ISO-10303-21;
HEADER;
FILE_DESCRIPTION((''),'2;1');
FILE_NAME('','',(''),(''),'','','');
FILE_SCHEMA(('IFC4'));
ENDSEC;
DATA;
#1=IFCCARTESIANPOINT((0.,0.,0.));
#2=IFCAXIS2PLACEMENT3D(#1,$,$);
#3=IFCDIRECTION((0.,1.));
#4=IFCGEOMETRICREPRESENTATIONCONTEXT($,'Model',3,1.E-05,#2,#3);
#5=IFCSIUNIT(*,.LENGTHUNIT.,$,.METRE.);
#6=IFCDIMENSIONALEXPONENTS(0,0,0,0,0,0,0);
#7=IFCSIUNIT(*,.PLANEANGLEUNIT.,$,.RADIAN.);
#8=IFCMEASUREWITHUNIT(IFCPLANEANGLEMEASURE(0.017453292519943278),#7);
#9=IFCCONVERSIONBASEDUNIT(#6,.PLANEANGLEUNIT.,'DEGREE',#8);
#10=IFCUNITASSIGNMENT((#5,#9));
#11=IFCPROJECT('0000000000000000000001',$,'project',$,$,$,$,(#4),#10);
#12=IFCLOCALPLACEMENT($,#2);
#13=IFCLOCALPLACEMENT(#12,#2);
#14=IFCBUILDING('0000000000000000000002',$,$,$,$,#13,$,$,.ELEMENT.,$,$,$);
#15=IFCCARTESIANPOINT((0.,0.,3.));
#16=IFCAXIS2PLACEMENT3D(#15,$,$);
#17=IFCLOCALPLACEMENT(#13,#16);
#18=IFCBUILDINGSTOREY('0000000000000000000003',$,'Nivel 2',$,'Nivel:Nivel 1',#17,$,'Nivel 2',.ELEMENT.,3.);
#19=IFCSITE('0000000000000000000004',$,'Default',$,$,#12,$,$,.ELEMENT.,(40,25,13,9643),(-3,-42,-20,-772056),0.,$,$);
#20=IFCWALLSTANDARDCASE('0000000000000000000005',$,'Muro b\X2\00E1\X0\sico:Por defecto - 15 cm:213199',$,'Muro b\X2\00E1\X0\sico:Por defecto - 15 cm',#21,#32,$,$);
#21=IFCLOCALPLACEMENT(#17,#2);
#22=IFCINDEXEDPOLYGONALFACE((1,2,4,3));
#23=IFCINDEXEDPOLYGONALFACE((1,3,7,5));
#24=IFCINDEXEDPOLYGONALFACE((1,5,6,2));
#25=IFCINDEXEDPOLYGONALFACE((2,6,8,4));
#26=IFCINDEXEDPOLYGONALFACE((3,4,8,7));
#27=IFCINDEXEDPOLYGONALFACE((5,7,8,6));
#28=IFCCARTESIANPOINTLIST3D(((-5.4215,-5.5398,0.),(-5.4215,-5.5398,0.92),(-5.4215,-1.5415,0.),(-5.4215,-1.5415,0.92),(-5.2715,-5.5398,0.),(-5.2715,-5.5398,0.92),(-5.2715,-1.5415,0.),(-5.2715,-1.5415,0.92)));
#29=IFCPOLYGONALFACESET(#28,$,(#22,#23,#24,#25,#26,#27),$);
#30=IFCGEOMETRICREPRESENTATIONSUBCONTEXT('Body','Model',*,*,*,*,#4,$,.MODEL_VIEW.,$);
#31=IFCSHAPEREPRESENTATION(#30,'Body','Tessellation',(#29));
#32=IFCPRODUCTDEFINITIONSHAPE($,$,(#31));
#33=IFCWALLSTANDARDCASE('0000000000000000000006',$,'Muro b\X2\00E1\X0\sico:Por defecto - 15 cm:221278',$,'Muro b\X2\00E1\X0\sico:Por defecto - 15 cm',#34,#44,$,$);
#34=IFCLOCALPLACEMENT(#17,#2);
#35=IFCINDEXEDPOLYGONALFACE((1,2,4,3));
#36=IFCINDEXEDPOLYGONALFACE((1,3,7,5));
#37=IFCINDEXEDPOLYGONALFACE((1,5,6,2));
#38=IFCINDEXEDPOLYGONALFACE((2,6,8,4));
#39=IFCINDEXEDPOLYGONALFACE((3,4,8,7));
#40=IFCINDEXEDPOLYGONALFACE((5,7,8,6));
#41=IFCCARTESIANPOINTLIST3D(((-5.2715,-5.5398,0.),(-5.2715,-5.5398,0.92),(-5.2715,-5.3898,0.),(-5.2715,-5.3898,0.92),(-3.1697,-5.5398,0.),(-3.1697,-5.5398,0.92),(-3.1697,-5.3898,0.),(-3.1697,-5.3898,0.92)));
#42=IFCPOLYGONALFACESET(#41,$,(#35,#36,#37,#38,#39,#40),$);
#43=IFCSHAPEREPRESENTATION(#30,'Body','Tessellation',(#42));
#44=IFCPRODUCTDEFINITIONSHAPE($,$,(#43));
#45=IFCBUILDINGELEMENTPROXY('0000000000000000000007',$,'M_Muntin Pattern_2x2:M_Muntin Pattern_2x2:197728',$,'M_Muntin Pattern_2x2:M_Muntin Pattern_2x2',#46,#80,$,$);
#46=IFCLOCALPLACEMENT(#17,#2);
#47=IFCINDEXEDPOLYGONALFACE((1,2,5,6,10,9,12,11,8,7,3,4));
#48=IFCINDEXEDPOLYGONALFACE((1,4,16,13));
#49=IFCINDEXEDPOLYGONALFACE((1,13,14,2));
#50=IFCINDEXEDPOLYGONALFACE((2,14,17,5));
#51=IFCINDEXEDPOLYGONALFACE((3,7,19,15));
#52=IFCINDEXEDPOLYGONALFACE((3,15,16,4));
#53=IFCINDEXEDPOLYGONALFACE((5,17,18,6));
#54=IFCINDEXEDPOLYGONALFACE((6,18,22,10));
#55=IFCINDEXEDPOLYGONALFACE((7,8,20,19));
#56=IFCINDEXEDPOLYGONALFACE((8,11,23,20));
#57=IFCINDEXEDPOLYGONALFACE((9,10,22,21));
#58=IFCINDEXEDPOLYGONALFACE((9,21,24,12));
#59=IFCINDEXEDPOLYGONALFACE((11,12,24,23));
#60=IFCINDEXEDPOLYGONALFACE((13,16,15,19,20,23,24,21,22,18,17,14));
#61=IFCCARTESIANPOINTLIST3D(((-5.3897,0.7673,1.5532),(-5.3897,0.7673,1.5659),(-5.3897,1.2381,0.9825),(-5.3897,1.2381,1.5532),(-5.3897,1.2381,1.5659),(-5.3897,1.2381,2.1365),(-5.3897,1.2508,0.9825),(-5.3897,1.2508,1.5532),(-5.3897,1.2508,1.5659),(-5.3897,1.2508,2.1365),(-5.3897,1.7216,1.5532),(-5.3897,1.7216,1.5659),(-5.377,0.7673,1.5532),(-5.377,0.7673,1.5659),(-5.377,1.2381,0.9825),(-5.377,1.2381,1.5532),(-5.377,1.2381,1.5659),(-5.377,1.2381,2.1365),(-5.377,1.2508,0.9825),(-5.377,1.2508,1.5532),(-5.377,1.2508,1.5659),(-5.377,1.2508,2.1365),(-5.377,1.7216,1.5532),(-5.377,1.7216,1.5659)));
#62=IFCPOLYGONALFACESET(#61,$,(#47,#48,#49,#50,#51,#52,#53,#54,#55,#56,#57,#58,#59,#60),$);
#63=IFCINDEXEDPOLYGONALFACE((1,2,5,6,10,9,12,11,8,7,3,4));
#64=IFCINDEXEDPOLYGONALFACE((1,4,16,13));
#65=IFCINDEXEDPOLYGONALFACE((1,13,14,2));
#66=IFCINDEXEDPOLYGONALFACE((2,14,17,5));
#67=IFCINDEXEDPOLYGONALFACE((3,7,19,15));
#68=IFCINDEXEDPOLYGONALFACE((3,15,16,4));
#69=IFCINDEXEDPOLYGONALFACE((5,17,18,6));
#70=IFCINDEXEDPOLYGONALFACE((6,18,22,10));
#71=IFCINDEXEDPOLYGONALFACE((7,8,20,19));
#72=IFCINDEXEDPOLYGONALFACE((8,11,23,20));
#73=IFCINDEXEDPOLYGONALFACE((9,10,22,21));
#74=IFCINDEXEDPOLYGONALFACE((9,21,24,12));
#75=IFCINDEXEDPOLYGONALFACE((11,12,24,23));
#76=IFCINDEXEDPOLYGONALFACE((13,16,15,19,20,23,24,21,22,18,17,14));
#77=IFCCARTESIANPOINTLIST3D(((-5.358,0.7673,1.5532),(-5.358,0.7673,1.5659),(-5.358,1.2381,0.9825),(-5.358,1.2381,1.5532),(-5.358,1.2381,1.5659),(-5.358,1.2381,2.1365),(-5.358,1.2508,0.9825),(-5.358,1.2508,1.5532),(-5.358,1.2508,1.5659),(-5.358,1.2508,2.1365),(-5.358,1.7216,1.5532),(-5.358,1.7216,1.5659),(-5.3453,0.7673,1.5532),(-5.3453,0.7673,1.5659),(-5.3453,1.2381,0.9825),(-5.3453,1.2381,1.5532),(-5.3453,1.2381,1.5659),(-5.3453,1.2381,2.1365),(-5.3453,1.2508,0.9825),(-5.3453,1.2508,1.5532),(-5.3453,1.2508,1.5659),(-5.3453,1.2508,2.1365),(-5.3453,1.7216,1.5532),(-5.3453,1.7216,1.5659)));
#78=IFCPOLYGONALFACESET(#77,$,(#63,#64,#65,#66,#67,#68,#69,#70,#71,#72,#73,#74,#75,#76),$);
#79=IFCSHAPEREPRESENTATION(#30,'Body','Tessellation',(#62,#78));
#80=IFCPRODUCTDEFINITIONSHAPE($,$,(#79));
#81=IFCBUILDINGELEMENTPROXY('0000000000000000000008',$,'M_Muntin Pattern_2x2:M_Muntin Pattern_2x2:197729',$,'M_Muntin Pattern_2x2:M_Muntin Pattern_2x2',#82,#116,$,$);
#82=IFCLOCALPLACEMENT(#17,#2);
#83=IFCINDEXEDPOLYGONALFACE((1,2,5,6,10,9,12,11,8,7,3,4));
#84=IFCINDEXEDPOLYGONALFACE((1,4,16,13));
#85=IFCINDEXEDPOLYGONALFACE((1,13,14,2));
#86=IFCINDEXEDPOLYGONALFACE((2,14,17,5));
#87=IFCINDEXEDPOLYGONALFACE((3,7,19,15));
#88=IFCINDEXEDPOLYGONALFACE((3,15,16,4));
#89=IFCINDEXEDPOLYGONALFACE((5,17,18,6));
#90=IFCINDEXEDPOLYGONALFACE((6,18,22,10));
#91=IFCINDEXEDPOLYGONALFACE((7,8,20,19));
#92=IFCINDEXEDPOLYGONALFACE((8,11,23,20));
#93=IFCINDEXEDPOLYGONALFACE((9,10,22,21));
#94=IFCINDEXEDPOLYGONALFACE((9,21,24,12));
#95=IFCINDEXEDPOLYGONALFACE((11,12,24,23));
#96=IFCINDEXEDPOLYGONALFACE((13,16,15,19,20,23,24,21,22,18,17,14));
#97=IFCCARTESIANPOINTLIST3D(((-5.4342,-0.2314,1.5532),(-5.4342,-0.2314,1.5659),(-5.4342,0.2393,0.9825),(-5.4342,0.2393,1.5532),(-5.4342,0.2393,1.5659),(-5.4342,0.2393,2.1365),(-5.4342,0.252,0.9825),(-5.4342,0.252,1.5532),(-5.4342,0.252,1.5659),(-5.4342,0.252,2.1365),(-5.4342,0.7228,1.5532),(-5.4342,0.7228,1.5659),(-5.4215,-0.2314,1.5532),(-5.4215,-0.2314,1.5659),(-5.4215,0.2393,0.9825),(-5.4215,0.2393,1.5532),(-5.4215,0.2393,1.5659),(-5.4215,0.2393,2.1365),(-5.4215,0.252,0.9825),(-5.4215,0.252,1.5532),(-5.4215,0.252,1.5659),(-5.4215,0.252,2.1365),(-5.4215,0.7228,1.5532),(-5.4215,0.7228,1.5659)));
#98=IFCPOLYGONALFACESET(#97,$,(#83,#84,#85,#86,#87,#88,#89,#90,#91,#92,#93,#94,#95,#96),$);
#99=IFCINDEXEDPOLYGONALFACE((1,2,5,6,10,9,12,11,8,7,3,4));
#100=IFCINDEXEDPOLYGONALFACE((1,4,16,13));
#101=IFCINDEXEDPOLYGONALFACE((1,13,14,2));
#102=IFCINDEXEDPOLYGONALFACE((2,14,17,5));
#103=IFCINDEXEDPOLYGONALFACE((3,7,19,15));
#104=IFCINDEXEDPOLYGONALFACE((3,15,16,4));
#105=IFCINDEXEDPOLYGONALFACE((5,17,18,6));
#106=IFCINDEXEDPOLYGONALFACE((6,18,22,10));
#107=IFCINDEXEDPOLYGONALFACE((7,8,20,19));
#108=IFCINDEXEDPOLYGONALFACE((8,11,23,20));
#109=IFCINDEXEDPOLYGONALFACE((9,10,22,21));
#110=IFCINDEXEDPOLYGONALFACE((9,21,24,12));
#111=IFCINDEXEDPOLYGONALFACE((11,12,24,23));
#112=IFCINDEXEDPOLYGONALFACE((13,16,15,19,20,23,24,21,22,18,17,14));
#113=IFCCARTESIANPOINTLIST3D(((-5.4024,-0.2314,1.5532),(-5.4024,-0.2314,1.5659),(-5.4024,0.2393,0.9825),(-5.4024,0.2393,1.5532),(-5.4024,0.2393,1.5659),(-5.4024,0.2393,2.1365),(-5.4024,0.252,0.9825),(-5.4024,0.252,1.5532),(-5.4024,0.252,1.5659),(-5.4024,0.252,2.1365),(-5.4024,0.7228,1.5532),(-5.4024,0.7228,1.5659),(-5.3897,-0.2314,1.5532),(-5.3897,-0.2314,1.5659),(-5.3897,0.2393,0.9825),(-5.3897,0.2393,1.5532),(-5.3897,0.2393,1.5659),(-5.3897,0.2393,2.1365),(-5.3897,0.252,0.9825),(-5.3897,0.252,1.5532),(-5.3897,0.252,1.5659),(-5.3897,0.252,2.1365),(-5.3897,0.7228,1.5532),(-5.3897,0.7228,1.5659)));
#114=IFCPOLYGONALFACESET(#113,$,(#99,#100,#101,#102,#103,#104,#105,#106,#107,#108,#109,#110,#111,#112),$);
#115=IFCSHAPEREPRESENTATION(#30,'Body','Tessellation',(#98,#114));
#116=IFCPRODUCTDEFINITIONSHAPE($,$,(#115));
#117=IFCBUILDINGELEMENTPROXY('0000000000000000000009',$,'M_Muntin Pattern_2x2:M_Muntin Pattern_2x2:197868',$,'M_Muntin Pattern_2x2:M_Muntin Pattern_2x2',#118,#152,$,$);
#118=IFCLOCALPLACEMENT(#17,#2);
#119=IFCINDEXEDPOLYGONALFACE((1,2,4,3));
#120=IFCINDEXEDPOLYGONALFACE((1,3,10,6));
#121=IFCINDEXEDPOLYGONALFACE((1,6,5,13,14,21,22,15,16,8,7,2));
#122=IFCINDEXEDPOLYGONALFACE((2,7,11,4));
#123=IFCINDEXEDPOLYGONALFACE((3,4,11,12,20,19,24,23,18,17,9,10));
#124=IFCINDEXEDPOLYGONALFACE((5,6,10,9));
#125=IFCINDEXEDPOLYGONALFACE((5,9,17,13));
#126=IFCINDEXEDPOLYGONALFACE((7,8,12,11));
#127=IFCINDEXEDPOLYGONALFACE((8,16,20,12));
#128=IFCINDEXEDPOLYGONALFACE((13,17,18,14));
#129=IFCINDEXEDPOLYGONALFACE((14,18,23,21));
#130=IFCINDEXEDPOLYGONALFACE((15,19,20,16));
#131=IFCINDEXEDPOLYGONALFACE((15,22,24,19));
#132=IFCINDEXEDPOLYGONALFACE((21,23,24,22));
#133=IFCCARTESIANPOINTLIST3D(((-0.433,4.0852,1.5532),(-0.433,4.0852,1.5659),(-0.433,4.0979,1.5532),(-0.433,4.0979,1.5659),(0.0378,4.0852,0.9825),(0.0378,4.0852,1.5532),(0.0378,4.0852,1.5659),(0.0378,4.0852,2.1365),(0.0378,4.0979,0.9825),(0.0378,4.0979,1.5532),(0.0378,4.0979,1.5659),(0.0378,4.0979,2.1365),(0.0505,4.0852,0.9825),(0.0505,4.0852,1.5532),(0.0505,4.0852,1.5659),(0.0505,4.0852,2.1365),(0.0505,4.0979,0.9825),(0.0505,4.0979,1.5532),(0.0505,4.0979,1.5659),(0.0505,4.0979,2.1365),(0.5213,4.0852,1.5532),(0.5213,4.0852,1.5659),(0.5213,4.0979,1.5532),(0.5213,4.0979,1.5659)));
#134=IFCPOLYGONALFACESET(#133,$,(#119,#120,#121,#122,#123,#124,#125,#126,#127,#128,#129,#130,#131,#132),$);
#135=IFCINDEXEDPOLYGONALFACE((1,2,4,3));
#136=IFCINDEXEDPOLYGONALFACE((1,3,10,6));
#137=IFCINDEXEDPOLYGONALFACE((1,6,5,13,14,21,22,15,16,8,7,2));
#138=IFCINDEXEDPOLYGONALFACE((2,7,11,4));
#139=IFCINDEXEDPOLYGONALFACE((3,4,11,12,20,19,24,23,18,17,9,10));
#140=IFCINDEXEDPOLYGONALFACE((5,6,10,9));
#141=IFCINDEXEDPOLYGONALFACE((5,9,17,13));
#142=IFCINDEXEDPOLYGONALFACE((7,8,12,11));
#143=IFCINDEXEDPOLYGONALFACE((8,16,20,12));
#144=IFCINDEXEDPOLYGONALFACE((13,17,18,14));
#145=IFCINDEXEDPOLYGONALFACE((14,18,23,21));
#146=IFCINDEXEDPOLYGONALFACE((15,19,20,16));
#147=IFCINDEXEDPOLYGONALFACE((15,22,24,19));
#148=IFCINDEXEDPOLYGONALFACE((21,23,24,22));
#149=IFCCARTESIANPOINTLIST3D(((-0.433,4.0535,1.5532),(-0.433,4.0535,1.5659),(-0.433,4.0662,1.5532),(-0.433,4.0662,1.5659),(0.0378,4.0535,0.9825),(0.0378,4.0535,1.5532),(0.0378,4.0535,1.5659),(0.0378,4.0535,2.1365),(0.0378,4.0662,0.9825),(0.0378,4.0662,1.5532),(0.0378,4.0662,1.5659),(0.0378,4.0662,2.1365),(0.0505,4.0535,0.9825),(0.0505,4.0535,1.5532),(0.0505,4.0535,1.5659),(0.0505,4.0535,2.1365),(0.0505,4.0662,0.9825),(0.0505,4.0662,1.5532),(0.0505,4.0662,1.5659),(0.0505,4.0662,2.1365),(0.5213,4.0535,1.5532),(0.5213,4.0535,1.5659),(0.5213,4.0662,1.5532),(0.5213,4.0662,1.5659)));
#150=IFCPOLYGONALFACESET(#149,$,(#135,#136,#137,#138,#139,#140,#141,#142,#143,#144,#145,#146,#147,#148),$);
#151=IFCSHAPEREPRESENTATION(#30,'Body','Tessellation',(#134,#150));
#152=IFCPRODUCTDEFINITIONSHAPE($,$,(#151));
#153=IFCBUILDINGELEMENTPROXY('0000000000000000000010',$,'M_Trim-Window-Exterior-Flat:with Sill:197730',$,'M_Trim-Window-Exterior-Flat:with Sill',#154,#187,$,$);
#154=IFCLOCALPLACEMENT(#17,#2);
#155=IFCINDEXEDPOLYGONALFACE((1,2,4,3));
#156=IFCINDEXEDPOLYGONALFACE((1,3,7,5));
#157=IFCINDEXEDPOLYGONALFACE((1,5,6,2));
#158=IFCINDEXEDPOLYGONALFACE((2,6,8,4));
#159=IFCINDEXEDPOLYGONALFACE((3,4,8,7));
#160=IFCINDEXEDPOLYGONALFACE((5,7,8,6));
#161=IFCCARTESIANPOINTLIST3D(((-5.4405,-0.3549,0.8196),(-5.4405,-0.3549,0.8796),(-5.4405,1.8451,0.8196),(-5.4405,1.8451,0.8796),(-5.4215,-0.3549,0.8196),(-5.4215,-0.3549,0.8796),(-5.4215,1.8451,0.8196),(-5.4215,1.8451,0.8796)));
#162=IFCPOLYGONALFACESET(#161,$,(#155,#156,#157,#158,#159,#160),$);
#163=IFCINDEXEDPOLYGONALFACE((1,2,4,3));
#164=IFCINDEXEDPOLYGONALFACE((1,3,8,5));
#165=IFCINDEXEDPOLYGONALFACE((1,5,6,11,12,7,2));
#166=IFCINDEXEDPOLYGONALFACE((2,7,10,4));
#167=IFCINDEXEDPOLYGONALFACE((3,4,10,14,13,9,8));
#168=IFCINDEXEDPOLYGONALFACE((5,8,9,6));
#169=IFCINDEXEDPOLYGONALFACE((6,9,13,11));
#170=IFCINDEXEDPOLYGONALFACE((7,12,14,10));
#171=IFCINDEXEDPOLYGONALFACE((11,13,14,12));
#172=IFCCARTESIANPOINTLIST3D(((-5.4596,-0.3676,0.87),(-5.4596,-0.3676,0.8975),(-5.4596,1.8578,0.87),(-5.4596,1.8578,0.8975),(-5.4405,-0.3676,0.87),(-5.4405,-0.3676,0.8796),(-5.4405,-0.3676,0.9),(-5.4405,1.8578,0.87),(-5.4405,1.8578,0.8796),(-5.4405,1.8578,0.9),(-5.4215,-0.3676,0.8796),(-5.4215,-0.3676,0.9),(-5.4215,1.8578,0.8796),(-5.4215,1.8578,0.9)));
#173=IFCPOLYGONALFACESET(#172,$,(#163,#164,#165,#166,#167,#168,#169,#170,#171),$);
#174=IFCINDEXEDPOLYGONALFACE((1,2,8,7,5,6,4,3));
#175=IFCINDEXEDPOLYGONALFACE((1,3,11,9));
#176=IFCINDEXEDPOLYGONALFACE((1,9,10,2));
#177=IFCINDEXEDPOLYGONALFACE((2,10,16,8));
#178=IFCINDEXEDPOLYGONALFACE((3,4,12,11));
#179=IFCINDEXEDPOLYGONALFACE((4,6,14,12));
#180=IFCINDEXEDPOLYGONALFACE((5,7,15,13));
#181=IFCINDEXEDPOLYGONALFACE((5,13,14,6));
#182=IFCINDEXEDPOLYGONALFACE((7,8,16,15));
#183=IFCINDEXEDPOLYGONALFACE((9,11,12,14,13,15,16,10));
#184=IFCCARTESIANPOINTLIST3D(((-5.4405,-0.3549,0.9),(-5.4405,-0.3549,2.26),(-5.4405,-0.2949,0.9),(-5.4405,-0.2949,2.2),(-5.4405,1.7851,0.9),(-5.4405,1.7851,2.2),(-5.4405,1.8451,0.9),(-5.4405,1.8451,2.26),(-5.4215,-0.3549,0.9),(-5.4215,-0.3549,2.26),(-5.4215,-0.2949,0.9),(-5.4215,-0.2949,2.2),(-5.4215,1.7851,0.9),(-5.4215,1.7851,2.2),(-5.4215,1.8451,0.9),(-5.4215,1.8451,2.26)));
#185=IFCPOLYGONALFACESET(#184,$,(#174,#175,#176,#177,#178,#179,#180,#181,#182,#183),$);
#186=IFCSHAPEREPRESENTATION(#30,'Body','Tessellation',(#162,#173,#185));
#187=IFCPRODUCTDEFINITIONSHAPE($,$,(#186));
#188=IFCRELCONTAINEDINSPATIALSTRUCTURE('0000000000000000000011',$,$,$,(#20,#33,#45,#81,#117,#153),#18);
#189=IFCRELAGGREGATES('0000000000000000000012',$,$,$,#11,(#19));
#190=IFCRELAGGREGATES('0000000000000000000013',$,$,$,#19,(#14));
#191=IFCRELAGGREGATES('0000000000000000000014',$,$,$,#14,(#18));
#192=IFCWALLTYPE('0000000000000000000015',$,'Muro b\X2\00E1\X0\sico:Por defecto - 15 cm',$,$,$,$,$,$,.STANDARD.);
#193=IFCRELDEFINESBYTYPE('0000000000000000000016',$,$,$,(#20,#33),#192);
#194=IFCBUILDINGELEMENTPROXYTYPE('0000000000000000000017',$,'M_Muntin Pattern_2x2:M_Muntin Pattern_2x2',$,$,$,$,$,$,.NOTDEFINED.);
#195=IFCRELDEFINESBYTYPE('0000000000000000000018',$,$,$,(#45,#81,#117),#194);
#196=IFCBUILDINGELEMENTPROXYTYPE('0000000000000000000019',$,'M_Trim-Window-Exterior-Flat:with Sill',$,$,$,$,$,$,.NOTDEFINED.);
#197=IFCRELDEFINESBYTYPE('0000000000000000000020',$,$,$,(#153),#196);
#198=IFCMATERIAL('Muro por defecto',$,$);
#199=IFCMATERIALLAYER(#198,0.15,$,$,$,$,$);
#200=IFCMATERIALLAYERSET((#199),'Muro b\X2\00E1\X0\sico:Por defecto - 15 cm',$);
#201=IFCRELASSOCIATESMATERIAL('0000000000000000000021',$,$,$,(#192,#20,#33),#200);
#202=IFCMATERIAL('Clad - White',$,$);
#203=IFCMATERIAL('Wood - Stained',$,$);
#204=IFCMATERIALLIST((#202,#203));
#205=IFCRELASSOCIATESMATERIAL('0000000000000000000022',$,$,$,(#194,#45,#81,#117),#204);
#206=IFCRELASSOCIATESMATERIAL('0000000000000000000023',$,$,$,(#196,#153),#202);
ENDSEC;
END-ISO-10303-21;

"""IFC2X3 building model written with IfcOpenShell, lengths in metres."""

from ifc_helpers import new_model, entity, si_unit, converted_unit, direction, frame, frame_2d, origin, place, context, subcontext, project, spatial, polyline, rectangle, outline, extrude, source, transform, mapped, material, material_list, layer, layer_set, layer_usage, type_object, type_shapes, element, save


model = new_model("IFC2X3")

# Units and contexts
model_context = context("Model", 3, precision=1e-05, world=origin(), true_north=direction((0.0, 1.0)))
body_context = subcontext(model_context, "Body", "Model", "MODEL_VIEW")
ifc_project = project(units=[si_unit("LENGTHUNIT", "METRE"), converted_unit("PLANEANGLEUNIT", "DEGREE", entity("IfcPlaneAngleMeasure", 0.017453292519943278), si_unit("PLANEANGLEUNIT", "RADIAN"), dimensions=[0, 0, 0, 0, 0, 0, 0])], contexts=[model_context])

# Site, building, storey
site_placement = place(None, origin())
site = spatial("IfcSite", under=ifc_project, at=site_placement, Name="Default", CompositionType="ELEMENT", RefLatitude=(40, 25, 13, 9643), RefLongitude=(-3, -42, -20, -772056), RefElevation=0.0)
building_placement = place(site_placement, origin())
building = spatial("IfcBuilding", under=site, at=building_placement, CompositionType="ELEMENT")
storey_placement = place(building_placement, frame((0.0, 0.0, 3.0)))
storey = spatial("IfcBuildingStorey", under=building, at=storey_placement, Name="Nivel 2", ObjectType="Nivel:Nivel 1", LongName="Nivel 2", CompositionType="ELEMENT", Elevation=3.0)

# Shared definitions
ifc_material_1 = material(Name="Muro por defecto")
ifc_layer_1 = layer(ifc_material_1, 0.15)
ifc_layer_set_1 = layer_set([ifc_layer_1], Name="Muro básico:Por defecto - 15 cm")
wall_type = type_object("IfcWallType", Name="Muro básico:Por defecto - 15 cm", PredefinedType="STANDARD", material=ifc_layer_set_1)

# Walls
ifc_layer_usage_1 = layer_usage(ifc_layer_set_1, "AXIS2", "NEGATIVE", 0.075)
wall_1_placement = place(storey_placement, frame((-5.3465, -1.5415, 0.0), z_axis=(0.0, 0.0, 1.0), x_axis=(0.0, -1.0, 0.0)))
element("IfcWallStandardCase", 1, at=wall_1_placement, inside=storey, type_object=wall_type, material=ifc_layer_usage_1, Name="Muro básico:Por defecto - 15 cm:213199", ObjectType="Muro básico:Por defecto - 15 cm", context=body_context, shape_type="SweptSolid", body=[
    extrude(rectangle(XDim=3.9982, YDim=0.15, at=frame_2d((1.9991, 0.0), x_axis=(-1.0, 0.0))), origin(), (0.0, 0.0, 1.0), 0.92),
])
ifc_layer_usage_2 = layer_usage(ifc_layer_set_1, "AXIS2", "POSITIVE", -0.075)
wall_2_placement = place(storey_placement, frame((-5.2715, -5.4648, 0.0)))
element("IfcWallStandardCase", 2, at=wall_2_placement, inside=storey, type_object=wall_type, material=ifc_layer_usage_2, Name="Muro básico:Por defecto - 15 cm:221278", ObjectType="Muro básico:Por defecto - 15 cm", context=body_context, shape_type="SweptSolid", body=[
    extrude(rectangle(XDim=2.1018, YDim=0.15, at=frame_2d((1.0509, 0.0), x_axis=(-1.0, 0.0))), origin(), (0.0, 0.0, 1.0), 0.92),
])

# Building element proxies
ifc_material_2 = material(Name="Clad - White")
ifc_material_3 = material(Name="Wood - Stained")
ifc_material_list_1 = material_list([ifc_material_2, ifc_material_3])
building_element_proxy_type_1 = type_object("IfcBuildingElementProxyType", Name="M_Muntin Pattern_2x2:M_Muntin Pattern_2x2", PredefinedType="NOTDEFINED", material=ifc_material_list_1)
shared_shape_1 = source(origin(), body_context, "Body", "SweptSolid", [
    extrude(outline(polyline([(0.0064, -0.0064), (0.577, -0.0064), (0.577, 0.0063), (0.0064, 0.0063), (0.0064, 0.4771), (-0.0063, 0.4771), (-0.0063, 0.0063), (-0.577, 0.0063), (-0.577, -0.0064), (-0.0063, -0.0064), (-0.0063, -0.4771), (0.0064, -0.4771), (0.0064, -0.0064)])), frame((0.0, 0.0095, 0.577), z_axis=(0.0, 1.0, 0.0), x_axis=(0.0, 0.0, 1.0)), (0.0, 0.0, 1.0), 0.0127),
    extrude(outline(polyline([(0.0064, -0.0064), (0.577, -0.0064), (0.577, 0.0063), (0.0064, 0.0063), (0.0064, 0.4771), (-0.0063, 0.4771), (-0.0063, 0.0063), (-0.577, 0.0063), (-0.577, -0.0064), (-0.0063, -0.0064), (-0.0063, -0.4771), (0.0064, -0.4771), (0.0064, -0.0064)])), frame((0.0, -0.0222, 0.577), z_axis=(0.0, 1.0, 0.0), x_axis=(0.0, 0.0, 1.0)), (0.0, 0.0, 1.0), 0.0127),
])
type_shapes(building_element_proxy_type_1, [shared_shape_1])
for number, where, z_axis, x_axis, name in (
    (3, (-5.3675, 1.2444, 0.9825), (0.0, 0.0, 1.0), (0.0, 1.0, 0.0), "M_Muntin Pattern_2x2:M_Muntin Pattern_2x2:197728"),
    (4, (-5.412, 0.2457, 0.9825), (0.0, 0.0, 1.0), (0.0, 1.0, 0.0), "M_Muntin Pattern_2x2:M_Muntin Pattern_2x2:197729"),
):
    element("IfcBuildingElementProxy", number, at=place(storey_placement, frame(where, z_axis=z_axis, x_axis=x_axis)), inside=storey, type_object=building_element_proxy_type_1, material=ifc_material_list_1, Name=name, ObjectType="M_Muntin Pattern_2x2:M_Muntin Pattern_2x2", context=body_context, shape_type="MappedRepresentation", body=[
        mapped(shared_shape_1, transform((0.0, 0.0, 0.0), scale=1.0)),
    ])
proxy_1_placement = place(storey_placement, frame((0.0442, 4.0757, 0.9825)))
element("IfcBuildingElementProxy", 5, at=proxy_1_placement, inside=storey, type_object=building_element_proxy_type_1, material=ifc_material_list_1, Name="M_Muntin Pattern_2x2:M_Muntin Pattern_2x2:197868", ObjectType="M_Muntin Pattern_2x2:M_Muntin Pattern_2x2", context=body_context, shape_type="MappedRepresentation", body=[
    mapped(shared_shape_1, transform((0.0, 0.0, 0.0), scale=1.0)),
])
building_element_proxy_type_2 = type_object("IfcBuildingElementProxyType", Name="M_Trim-Window-Exterior-Flat:with Sill", PredefinedType="NOTDEFINED", material=ifc_material_2)
shared_shape_2 = source(origin(), body_context, "Body", "SweptSolid", [
    extrude(rectangle(XDim=2.2, YDim=0.06, at=frame_2d((0.0, 0.0), x_axis=(1.0, 0.0))), frame((0.0, -1.3504, 0.0), z_axis=(0.0, 0.0, 1.0), x_axis=(-1.0, 0.0, 0.0)), (0.0, 0.0, 1.0), 0.019),
    extrude(outline(polyline([(-0.019, -0.0152), (0.0, -0.0152), (0.0, -0.0057), (0.019, -0.0057), (0.019, 0.0148), (0.0, 0.0148), (-0.019, 0.0123), (-0.019, -0.0152)])), frame((-1.1127, -1.3148, 0.019), z_axis=(1.0, 0.0, 0.0), x_axis=(0.0, 0.0, -1.0)), (0.0, 0.0, 1.0), 2.2254),
    extrude(outline(polyline([(-0.695, -1.1), (0.665, -1.1), (0.665, -1.04), (-0.635, -1.04), (-0.635, 1.04), (0.665, 1.04), (0.665, 1.1), (-0.695, 1.1), (-0.695, -1.1)])), frame((0.0, -0.635, 0.0), z_axis=(0.0, 0.0, 1.0), x_axis=(0.0, -1.0, 0.0)), (0.0, 0.0, 1.0), 0.019),
])
type_shapes(building_element_proxy_type_2, [shared_shape_2])
proxy_2_placement = place(storey_placement, frame((-5.4215, 0.7451, 2.2), z_axis=(-1.0, 0.0, 0.0), x_axis=(0.0, -1.0, 0.0)))
element("IfcBuildingElementProxy", 6, at=proxy_2_placement, inside=storey, type_object=building_element_proxy_type_2, material=ifc_material_2, Name="M_Trim-Window-Exterior-Flat:with Sill:197730", ObjectType="M_Trim-Window-Exterior-Flat:with Sill", context=body_context, shape_type="MappedRepresentation", body=[
    mapped(shared_shape_2, transform((0.0, 0.0, 0.0), scale=1.0)),
])

save(model, "model.ifc")
